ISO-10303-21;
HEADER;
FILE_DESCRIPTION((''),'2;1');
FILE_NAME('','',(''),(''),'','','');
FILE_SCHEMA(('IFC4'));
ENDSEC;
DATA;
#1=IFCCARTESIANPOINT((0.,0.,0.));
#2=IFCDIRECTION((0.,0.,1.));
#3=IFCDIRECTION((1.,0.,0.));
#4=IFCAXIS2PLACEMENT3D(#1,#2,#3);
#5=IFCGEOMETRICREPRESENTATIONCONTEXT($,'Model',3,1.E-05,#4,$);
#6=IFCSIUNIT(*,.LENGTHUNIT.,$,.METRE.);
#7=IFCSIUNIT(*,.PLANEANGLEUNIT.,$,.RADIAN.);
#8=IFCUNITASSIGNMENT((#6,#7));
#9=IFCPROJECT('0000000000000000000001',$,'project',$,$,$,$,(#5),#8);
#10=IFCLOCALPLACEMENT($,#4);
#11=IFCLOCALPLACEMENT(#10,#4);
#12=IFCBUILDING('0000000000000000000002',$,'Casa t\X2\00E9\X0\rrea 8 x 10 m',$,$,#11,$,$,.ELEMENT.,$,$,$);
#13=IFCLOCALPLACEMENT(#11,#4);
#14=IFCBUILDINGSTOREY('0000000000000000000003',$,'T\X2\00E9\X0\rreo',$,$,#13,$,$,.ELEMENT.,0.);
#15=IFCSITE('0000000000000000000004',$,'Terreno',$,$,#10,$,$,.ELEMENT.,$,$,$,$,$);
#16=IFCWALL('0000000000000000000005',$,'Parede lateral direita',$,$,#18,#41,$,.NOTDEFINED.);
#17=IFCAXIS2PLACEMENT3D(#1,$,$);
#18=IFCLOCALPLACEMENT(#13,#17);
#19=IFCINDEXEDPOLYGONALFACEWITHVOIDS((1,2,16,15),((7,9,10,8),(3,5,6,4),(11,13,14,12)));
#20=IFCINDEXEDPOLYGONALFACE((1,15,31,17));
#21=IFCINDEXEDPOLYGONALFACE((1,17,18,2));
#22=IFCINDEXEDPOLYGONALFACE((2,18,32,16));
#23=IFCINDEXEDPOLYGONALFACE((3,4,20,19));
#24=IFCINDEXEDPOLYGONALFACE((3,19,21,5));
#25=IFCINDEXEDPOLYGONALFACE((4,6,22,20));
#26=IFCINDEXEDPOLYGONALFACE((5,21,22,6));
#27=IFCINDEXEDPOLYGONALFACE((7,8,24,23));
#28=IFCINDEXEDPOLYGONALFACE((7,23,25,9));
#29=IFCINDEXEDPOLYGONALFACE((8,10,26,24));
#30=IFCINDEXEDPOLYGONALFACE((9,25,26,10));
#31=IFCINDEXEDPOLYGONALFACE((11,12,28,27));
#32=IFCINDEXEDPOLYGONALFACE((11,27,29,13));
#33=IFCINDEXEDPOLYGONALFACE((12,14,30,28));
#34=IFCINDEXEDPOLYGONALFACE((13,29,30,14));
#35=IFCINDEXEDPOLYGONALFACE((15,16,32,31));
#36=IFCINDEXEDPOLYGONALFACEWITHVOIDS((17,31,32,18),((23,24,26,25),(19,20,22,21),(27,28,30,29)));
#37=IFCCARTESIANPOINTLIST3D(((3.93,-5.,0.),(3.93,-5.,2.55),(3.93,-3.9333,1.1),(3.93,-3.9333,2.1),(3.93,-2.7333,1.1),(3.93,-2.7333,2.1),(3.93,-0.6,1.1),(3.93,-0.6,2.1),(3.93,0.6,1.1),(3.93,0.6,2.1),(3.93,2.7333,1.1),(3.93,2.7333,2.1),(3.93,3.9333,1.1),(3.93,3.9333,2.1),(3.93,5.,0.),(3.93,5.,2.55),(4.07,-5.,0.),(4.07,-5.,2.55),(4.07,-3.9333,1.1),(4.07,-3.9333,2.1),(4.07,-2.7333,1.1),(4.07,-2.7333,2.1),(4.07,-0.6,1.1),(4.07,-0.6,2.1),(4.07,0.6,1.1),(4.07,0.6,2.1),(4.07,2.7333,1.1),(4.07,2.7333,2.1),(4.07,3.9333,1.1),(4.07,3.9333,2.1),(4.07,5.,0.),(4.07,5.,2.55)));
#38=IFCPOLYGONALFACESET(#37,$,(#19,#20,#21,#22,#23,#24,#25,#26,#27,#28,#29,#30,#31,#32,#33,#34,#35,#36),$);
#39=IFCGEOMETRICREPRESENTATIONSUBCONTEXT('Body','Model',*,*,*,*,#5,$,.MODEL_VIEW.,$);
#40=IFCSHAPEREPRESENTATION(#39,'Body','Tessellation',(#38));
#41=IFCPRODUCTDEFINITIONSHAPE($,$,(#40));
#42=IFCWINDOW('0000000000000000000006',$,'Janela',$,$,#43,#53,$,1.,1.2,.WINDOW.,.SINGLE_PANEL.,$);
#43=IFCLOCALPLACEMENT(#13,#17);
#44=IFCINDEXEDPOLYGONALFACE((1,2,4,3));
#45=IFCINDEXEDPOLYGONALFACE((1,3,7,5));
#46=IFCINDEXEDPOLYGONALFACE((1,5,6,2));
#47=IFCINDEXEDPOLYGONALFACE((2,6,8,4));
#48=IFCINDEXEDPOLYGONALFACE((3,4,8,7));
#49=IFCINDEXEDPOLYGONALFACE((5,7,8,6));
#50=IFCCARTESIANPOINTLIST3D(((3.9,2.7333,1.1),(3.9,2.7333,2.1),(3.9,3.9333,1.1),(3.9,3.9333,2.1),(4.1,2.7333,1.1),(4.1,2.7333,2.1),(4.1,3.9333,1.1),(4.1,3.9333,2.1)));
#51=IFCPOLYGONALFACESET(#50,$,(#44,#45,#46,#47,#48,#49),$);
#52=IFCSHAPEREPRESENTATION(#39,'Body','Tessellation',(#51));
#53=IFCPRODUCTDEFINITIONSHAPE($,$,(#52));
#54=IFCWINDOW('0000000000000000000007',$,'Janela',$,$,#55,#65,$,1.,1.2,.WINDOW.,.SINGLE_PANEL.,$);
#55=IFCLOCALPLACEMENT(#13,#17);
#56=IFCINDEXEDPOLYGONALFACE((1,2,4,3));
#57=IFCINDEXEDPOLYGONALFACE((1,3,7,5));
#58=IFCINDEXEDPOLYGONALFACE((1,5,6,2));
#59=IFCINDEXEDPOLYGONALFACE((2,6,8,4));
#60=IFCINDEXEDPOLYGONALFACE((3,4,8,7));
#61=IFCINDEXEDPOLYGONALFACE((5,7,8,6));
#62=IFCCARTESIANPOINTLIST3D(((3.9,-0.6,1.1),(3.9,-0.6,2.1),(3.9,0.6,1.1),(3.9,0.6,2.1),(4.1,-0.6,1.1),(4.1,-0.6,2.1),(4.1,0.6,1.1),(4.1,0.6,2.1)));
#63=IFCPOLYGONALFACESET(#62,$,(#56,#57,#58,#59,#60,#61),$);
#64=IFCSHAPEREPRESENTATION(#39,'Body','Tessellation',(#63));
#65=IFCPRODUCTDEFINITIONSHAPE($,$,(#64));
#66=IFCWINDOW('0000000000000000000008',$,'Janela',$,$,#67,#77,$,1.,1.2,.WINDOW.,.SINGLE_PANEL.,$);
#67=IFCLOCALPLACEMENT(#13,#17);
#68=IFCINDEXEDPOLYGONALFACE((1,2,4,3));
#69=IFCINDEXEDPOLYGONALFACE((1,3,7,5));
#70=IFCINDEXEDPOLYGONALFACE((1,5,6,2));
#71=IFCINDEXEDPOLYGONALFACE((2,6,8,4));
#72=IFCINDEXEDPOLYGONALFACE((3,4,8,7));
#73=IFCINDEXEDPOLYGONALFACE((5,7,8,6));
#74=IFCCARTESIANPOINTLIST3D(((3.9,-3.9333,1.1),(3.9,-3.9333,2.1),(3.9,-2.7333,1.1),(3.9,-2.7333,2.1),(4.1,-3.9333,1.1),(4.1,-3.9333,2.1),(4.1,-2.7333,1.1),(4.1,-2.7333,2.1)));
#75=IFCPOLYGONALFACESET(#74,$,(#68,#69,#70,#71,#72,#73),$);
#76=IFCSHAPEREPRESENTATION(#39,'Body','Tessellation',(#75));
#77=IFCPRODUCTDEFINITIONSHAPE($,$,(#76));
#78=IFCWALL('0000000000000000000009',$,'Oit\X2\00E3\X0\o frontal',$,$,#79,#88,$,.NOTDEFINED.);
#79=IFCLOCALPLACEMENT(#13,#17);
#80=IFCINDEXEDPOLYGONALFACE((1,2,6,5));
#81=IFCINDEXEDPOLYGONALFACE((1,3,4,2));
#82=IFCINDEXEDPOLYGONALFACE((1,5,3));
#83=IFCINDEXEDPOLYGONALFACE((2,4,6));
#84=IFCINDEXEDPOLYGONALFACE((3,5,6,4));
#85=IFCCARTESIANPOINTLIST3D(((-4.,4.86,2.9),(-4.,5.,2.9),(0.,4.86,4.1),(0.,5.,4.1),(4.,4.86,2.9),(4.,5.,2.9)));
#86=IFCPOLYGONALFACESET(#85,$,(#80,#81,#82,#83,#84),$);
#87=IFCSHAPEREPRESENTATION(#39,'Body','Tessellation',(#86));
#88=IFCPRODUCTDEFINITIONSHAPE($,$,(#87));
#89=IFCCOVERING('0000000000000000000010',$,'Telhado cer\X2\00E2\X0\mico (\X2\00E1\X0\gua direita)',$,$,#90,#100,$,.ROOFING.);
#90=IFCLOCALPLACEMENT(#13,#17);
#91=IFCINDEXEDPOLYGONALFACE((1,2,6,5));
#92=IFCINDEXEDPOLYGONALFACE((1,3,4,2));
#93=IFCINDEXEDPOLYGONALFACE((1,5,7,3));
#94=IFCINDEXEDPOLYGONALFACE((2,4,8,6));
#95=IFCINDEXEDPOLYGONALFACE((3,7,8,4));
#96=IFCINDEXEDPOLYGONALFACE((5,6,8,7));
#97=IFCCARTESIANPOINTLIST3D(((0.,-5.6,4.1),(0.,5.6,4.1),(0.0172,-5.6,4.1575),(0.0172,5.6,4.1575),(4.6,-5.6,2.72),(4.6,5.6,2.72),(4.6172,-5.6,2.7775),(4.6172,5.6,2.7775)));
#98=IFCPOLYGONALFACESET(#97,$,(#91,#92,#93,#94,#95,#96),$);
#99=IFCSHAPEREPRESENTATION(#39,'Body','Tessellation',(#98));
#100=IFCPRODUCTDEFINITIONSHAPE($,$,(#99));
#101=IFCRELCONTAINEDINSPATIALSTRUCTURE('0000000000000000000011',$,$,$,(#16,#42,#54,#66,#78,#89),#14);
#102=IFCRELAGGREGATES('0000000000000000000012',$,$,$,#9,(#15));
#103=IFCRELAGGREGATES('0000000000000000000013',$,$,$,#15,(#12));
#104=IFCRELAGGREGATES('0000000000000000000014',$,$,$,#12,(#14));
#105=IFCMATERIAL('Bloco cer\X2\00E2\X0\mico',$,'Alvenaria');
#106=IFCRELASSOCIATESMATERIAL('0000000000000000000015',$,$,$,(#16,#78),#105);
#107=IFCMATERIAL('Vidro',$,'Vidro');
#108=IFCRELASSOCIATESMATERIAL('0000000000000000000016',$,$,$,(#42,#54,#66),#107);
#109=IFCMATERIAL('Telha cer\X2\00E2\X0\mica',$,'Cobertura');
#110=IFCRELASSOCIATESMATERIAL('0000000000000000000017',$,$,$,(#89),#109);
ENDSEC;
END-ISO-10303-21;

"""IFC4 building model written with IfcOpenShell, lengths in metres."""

from ifc_helpers import new_model, si_unit, frame, origin_with_axes, origin_2d, place, context, subcontext, project, spatial, polyline, rectangle, outline, extrude, material, element, fill, save


model = new_model("IFC4")

# Units and contexts
model_context = context("Model", 3, precision=1e-05, world=origin_with_axes())
body_context = subcontext(model_context, "Body", "Model", "MODEL_VIEW")
ifc_project = project(units=[si_unit("LENGTHUNIT", "METRE"), si_unit("PLANEANGLEUNIT", "RADIAN")], contexts=[model_context])

# Site, building, storey
site_placement = place(None, origin_with_axes())
site = spatial("IfcSite", under=ifc_project, at=site_placement, Name="Terreno", CompositionType="ELEMENT")
building_placement = place(site_placement, origin_with_axes())
building = spatial("IfcBuilding", under=site, at=building_placement, Name="Casa térrea 8 x 10 m", CompositionType="ELEMENT")
storey_placement = place(building_placement, origin_with_axes())
storey = spatial("IfcBuildingStorey", under=building, at=storey_placement, Name="Térreo", CompositionType="ELEMENT", Elevation=0.0)

# Shared definitions
ifc_material_1 = material(Name="Bloco cerâmico", Category="Alvenaria")

# Wall, openings, windows
wall_1_placement = place(storey_placement, frame((4.0, 0.0, 0.0), z_axis=(0.0, 0.0, 1.0), x_axis=(1.0, 0.0, 0.0)))
wall_1 = element("IfcWall", 1, at=wall_1_placement, inside=storey, material=ifc_material_1, Name="Parede lateral direita", PredefinedType="NOTDEFINED", context=body_context, shape_type="SweptSolid", body=[
    extrude(rectangle(XDim=0.14, YDim=10.0, at=origin_2d()), None, (0.0, 0.0, 1.0), 2.55),
])
opening_1_placement = place(storey_placement, frame((4.0, 3.3333, 1.1), z_axis=(0.0, 0.0, 1.0), x_axis=(1.0, 0.0, 0.0)))
opening_1 = element("IfcOpeningElement", 2, at=opening_1_placement, cuts=wall_1, PredefinedType="OPENING", context=body_context, shape_type="SweptSolid", body=[
    extrude(rectangle(XDim=0.4, YDim=1.2, at=origin_2d()), None, (0.0, 0.0, 1.0), 1.0),
])
opening_2_placement = place(storey_placement, frame((4.0, 0.0, 1.1), z_axis=(0.0, 0.0, 1.0), x_axis=(1.0, 0.0, 0.0)))
opening_2 = element("IfcOpeningElement", 3, at=opening_2_placement, cuts=wall_1, PredefinedType="OPENING", context=body_context, shape_type="SweptSolid", body=[
    extrude(rectangle(XDim=0.4, YDim=1.2, at=origin_2d()), None, (0.0, 0.0, 1.0), 1.0),
])
opening_3_placement = place(storey_placement, frame((4.0, -3.3333, 1.1), z_axis=(0.0, 0.0, 1.0), x_axis=(1.0, 0.0, 0.0)))
opening_3 = element("IfcOpeningElement", 4, at=opening_3_placement, cuts=wall_1, PredefinedType="OPENING", context=body_context, shape_type="SweptSolid", body=[
    extrude(rectangle(XDim=0.4, YDim=1.2, at=origin_2d()), None, (0.0, 0.0, 1.0), 1.0),
])
ifc_material_2 = material(Name="Vidro", Category="Vidro")
window_1_placement = place(storey_placement, frame((4.0, 3.3333, 1.1), z_axis=(0.0, 0.0, 1.0), x_axis=(1.0, 0.0, 0.0)))
window_1 = element("IfcWindow", 5, at=window_1_placement, inside=storey, material=ifc_material_2, Name="Janela", OverallHeight=1.0, OverallWidth=1.2, PartitioningType="SINGLE_PANEL", PredefinedType="WINDOW", context=body_context, shape_type="SweptSolid", body=[
    extrude(rectangle(XDim=0.2, YDim=1.2, at=origin_2d()), None, (0.0, 0.0, 1.0), 1.0),
])
fill(opening_1, window_1)
window_2_placement = place(storey_placement, frame((4.0, 0.0, 1.1), z_axis=(0.0, 0.0, 1.0), x_axis=(1.0, 0.0, 0.0)))
window_2 = element("IfcWindow", 6, at=window_2_placement, inside=storey, material=ifc_material_2, Name="Janela", OverallHeight=1.0, OverallWidth=1.2, PartitioningType="SINGLE_PANEL", PredefinedType="WINDOW", context=body_context, shape_type="SweptSolid", body=[
    extrude(rectangle(XDim=0.2, YDim=1.2, at=origin_2d()), None, (0.0, 0.0, 1.0), 1.0),
])
fill(opening_2, window_2)
window_3_placement = place(storey_placement, frame((4.0, -3.3333, 1.1), z_axis=(0.0, 0.0, 1.0), x_axis=(1.0, 0.0, 0.0)))
window_3 = element("IfcWindow", 7, at=window_3_placement, inside=storey, material=ifc_material_2, Name="Janela", OverallHeight=1.0, OverallWidth=1.2, PartitioningType="SINGLE_PANEL", PredefinedType="WINDOW", context=body_context, shape_type="SweptSolid", body=[
    extrude(rectangle(XDim=0.2, YDim=1.2, at=origin_2d()), None, (0.0, 0.0, 1.0), 1.0),
])
fill(opening_3, window_3)

# Wall
wall_2_placement = place(storey_placement, frame((0.0, 5.0, 2.9), z_axis=(0.0, -1.0, 0.0), x_axis=(1.0, 0.0, 0.0)))
element("IfcWall", 8, at=wall_2_placement, inside=storey, material=ifc_material_1, Name="Oitão frontal", PredefinedType="NOTDEFINED", context=body_context, shape_type="SweptSolid", body=[
    extrude(outline(polyline([(-4.0, 0.0), (4.0, 0.0), (0.0, 1.2), (-4.0, 0.0)])), None, (0.0, 0.0, 1.0), 0.14),
])

# Covering
ifc_material_3 = material(Name="Telha cerâmica", Category="Cobertura")
covering_placement = place(storey_placement, frame((2.3, 0.0, 3.41), z_axis=(0.287348, 0.0, 0.957826), x_axis=(0.957826, 0.0, -0.287348)))
element("IfcCovering", 9, at=covering_placement, inside=storey, material=ifc_material_3, Name="Telhado cerâmico (água direita)", PredefinedType="ROOFING", context=body_context, shape_type="SweptSolid", body=[
    extrude(rectangle(XDim=4.8025, YDim=11.2, at=origin_2d()), None, (0.0, 0.0, 1.0), 0.06),
])

save(model, "model.ifc")
